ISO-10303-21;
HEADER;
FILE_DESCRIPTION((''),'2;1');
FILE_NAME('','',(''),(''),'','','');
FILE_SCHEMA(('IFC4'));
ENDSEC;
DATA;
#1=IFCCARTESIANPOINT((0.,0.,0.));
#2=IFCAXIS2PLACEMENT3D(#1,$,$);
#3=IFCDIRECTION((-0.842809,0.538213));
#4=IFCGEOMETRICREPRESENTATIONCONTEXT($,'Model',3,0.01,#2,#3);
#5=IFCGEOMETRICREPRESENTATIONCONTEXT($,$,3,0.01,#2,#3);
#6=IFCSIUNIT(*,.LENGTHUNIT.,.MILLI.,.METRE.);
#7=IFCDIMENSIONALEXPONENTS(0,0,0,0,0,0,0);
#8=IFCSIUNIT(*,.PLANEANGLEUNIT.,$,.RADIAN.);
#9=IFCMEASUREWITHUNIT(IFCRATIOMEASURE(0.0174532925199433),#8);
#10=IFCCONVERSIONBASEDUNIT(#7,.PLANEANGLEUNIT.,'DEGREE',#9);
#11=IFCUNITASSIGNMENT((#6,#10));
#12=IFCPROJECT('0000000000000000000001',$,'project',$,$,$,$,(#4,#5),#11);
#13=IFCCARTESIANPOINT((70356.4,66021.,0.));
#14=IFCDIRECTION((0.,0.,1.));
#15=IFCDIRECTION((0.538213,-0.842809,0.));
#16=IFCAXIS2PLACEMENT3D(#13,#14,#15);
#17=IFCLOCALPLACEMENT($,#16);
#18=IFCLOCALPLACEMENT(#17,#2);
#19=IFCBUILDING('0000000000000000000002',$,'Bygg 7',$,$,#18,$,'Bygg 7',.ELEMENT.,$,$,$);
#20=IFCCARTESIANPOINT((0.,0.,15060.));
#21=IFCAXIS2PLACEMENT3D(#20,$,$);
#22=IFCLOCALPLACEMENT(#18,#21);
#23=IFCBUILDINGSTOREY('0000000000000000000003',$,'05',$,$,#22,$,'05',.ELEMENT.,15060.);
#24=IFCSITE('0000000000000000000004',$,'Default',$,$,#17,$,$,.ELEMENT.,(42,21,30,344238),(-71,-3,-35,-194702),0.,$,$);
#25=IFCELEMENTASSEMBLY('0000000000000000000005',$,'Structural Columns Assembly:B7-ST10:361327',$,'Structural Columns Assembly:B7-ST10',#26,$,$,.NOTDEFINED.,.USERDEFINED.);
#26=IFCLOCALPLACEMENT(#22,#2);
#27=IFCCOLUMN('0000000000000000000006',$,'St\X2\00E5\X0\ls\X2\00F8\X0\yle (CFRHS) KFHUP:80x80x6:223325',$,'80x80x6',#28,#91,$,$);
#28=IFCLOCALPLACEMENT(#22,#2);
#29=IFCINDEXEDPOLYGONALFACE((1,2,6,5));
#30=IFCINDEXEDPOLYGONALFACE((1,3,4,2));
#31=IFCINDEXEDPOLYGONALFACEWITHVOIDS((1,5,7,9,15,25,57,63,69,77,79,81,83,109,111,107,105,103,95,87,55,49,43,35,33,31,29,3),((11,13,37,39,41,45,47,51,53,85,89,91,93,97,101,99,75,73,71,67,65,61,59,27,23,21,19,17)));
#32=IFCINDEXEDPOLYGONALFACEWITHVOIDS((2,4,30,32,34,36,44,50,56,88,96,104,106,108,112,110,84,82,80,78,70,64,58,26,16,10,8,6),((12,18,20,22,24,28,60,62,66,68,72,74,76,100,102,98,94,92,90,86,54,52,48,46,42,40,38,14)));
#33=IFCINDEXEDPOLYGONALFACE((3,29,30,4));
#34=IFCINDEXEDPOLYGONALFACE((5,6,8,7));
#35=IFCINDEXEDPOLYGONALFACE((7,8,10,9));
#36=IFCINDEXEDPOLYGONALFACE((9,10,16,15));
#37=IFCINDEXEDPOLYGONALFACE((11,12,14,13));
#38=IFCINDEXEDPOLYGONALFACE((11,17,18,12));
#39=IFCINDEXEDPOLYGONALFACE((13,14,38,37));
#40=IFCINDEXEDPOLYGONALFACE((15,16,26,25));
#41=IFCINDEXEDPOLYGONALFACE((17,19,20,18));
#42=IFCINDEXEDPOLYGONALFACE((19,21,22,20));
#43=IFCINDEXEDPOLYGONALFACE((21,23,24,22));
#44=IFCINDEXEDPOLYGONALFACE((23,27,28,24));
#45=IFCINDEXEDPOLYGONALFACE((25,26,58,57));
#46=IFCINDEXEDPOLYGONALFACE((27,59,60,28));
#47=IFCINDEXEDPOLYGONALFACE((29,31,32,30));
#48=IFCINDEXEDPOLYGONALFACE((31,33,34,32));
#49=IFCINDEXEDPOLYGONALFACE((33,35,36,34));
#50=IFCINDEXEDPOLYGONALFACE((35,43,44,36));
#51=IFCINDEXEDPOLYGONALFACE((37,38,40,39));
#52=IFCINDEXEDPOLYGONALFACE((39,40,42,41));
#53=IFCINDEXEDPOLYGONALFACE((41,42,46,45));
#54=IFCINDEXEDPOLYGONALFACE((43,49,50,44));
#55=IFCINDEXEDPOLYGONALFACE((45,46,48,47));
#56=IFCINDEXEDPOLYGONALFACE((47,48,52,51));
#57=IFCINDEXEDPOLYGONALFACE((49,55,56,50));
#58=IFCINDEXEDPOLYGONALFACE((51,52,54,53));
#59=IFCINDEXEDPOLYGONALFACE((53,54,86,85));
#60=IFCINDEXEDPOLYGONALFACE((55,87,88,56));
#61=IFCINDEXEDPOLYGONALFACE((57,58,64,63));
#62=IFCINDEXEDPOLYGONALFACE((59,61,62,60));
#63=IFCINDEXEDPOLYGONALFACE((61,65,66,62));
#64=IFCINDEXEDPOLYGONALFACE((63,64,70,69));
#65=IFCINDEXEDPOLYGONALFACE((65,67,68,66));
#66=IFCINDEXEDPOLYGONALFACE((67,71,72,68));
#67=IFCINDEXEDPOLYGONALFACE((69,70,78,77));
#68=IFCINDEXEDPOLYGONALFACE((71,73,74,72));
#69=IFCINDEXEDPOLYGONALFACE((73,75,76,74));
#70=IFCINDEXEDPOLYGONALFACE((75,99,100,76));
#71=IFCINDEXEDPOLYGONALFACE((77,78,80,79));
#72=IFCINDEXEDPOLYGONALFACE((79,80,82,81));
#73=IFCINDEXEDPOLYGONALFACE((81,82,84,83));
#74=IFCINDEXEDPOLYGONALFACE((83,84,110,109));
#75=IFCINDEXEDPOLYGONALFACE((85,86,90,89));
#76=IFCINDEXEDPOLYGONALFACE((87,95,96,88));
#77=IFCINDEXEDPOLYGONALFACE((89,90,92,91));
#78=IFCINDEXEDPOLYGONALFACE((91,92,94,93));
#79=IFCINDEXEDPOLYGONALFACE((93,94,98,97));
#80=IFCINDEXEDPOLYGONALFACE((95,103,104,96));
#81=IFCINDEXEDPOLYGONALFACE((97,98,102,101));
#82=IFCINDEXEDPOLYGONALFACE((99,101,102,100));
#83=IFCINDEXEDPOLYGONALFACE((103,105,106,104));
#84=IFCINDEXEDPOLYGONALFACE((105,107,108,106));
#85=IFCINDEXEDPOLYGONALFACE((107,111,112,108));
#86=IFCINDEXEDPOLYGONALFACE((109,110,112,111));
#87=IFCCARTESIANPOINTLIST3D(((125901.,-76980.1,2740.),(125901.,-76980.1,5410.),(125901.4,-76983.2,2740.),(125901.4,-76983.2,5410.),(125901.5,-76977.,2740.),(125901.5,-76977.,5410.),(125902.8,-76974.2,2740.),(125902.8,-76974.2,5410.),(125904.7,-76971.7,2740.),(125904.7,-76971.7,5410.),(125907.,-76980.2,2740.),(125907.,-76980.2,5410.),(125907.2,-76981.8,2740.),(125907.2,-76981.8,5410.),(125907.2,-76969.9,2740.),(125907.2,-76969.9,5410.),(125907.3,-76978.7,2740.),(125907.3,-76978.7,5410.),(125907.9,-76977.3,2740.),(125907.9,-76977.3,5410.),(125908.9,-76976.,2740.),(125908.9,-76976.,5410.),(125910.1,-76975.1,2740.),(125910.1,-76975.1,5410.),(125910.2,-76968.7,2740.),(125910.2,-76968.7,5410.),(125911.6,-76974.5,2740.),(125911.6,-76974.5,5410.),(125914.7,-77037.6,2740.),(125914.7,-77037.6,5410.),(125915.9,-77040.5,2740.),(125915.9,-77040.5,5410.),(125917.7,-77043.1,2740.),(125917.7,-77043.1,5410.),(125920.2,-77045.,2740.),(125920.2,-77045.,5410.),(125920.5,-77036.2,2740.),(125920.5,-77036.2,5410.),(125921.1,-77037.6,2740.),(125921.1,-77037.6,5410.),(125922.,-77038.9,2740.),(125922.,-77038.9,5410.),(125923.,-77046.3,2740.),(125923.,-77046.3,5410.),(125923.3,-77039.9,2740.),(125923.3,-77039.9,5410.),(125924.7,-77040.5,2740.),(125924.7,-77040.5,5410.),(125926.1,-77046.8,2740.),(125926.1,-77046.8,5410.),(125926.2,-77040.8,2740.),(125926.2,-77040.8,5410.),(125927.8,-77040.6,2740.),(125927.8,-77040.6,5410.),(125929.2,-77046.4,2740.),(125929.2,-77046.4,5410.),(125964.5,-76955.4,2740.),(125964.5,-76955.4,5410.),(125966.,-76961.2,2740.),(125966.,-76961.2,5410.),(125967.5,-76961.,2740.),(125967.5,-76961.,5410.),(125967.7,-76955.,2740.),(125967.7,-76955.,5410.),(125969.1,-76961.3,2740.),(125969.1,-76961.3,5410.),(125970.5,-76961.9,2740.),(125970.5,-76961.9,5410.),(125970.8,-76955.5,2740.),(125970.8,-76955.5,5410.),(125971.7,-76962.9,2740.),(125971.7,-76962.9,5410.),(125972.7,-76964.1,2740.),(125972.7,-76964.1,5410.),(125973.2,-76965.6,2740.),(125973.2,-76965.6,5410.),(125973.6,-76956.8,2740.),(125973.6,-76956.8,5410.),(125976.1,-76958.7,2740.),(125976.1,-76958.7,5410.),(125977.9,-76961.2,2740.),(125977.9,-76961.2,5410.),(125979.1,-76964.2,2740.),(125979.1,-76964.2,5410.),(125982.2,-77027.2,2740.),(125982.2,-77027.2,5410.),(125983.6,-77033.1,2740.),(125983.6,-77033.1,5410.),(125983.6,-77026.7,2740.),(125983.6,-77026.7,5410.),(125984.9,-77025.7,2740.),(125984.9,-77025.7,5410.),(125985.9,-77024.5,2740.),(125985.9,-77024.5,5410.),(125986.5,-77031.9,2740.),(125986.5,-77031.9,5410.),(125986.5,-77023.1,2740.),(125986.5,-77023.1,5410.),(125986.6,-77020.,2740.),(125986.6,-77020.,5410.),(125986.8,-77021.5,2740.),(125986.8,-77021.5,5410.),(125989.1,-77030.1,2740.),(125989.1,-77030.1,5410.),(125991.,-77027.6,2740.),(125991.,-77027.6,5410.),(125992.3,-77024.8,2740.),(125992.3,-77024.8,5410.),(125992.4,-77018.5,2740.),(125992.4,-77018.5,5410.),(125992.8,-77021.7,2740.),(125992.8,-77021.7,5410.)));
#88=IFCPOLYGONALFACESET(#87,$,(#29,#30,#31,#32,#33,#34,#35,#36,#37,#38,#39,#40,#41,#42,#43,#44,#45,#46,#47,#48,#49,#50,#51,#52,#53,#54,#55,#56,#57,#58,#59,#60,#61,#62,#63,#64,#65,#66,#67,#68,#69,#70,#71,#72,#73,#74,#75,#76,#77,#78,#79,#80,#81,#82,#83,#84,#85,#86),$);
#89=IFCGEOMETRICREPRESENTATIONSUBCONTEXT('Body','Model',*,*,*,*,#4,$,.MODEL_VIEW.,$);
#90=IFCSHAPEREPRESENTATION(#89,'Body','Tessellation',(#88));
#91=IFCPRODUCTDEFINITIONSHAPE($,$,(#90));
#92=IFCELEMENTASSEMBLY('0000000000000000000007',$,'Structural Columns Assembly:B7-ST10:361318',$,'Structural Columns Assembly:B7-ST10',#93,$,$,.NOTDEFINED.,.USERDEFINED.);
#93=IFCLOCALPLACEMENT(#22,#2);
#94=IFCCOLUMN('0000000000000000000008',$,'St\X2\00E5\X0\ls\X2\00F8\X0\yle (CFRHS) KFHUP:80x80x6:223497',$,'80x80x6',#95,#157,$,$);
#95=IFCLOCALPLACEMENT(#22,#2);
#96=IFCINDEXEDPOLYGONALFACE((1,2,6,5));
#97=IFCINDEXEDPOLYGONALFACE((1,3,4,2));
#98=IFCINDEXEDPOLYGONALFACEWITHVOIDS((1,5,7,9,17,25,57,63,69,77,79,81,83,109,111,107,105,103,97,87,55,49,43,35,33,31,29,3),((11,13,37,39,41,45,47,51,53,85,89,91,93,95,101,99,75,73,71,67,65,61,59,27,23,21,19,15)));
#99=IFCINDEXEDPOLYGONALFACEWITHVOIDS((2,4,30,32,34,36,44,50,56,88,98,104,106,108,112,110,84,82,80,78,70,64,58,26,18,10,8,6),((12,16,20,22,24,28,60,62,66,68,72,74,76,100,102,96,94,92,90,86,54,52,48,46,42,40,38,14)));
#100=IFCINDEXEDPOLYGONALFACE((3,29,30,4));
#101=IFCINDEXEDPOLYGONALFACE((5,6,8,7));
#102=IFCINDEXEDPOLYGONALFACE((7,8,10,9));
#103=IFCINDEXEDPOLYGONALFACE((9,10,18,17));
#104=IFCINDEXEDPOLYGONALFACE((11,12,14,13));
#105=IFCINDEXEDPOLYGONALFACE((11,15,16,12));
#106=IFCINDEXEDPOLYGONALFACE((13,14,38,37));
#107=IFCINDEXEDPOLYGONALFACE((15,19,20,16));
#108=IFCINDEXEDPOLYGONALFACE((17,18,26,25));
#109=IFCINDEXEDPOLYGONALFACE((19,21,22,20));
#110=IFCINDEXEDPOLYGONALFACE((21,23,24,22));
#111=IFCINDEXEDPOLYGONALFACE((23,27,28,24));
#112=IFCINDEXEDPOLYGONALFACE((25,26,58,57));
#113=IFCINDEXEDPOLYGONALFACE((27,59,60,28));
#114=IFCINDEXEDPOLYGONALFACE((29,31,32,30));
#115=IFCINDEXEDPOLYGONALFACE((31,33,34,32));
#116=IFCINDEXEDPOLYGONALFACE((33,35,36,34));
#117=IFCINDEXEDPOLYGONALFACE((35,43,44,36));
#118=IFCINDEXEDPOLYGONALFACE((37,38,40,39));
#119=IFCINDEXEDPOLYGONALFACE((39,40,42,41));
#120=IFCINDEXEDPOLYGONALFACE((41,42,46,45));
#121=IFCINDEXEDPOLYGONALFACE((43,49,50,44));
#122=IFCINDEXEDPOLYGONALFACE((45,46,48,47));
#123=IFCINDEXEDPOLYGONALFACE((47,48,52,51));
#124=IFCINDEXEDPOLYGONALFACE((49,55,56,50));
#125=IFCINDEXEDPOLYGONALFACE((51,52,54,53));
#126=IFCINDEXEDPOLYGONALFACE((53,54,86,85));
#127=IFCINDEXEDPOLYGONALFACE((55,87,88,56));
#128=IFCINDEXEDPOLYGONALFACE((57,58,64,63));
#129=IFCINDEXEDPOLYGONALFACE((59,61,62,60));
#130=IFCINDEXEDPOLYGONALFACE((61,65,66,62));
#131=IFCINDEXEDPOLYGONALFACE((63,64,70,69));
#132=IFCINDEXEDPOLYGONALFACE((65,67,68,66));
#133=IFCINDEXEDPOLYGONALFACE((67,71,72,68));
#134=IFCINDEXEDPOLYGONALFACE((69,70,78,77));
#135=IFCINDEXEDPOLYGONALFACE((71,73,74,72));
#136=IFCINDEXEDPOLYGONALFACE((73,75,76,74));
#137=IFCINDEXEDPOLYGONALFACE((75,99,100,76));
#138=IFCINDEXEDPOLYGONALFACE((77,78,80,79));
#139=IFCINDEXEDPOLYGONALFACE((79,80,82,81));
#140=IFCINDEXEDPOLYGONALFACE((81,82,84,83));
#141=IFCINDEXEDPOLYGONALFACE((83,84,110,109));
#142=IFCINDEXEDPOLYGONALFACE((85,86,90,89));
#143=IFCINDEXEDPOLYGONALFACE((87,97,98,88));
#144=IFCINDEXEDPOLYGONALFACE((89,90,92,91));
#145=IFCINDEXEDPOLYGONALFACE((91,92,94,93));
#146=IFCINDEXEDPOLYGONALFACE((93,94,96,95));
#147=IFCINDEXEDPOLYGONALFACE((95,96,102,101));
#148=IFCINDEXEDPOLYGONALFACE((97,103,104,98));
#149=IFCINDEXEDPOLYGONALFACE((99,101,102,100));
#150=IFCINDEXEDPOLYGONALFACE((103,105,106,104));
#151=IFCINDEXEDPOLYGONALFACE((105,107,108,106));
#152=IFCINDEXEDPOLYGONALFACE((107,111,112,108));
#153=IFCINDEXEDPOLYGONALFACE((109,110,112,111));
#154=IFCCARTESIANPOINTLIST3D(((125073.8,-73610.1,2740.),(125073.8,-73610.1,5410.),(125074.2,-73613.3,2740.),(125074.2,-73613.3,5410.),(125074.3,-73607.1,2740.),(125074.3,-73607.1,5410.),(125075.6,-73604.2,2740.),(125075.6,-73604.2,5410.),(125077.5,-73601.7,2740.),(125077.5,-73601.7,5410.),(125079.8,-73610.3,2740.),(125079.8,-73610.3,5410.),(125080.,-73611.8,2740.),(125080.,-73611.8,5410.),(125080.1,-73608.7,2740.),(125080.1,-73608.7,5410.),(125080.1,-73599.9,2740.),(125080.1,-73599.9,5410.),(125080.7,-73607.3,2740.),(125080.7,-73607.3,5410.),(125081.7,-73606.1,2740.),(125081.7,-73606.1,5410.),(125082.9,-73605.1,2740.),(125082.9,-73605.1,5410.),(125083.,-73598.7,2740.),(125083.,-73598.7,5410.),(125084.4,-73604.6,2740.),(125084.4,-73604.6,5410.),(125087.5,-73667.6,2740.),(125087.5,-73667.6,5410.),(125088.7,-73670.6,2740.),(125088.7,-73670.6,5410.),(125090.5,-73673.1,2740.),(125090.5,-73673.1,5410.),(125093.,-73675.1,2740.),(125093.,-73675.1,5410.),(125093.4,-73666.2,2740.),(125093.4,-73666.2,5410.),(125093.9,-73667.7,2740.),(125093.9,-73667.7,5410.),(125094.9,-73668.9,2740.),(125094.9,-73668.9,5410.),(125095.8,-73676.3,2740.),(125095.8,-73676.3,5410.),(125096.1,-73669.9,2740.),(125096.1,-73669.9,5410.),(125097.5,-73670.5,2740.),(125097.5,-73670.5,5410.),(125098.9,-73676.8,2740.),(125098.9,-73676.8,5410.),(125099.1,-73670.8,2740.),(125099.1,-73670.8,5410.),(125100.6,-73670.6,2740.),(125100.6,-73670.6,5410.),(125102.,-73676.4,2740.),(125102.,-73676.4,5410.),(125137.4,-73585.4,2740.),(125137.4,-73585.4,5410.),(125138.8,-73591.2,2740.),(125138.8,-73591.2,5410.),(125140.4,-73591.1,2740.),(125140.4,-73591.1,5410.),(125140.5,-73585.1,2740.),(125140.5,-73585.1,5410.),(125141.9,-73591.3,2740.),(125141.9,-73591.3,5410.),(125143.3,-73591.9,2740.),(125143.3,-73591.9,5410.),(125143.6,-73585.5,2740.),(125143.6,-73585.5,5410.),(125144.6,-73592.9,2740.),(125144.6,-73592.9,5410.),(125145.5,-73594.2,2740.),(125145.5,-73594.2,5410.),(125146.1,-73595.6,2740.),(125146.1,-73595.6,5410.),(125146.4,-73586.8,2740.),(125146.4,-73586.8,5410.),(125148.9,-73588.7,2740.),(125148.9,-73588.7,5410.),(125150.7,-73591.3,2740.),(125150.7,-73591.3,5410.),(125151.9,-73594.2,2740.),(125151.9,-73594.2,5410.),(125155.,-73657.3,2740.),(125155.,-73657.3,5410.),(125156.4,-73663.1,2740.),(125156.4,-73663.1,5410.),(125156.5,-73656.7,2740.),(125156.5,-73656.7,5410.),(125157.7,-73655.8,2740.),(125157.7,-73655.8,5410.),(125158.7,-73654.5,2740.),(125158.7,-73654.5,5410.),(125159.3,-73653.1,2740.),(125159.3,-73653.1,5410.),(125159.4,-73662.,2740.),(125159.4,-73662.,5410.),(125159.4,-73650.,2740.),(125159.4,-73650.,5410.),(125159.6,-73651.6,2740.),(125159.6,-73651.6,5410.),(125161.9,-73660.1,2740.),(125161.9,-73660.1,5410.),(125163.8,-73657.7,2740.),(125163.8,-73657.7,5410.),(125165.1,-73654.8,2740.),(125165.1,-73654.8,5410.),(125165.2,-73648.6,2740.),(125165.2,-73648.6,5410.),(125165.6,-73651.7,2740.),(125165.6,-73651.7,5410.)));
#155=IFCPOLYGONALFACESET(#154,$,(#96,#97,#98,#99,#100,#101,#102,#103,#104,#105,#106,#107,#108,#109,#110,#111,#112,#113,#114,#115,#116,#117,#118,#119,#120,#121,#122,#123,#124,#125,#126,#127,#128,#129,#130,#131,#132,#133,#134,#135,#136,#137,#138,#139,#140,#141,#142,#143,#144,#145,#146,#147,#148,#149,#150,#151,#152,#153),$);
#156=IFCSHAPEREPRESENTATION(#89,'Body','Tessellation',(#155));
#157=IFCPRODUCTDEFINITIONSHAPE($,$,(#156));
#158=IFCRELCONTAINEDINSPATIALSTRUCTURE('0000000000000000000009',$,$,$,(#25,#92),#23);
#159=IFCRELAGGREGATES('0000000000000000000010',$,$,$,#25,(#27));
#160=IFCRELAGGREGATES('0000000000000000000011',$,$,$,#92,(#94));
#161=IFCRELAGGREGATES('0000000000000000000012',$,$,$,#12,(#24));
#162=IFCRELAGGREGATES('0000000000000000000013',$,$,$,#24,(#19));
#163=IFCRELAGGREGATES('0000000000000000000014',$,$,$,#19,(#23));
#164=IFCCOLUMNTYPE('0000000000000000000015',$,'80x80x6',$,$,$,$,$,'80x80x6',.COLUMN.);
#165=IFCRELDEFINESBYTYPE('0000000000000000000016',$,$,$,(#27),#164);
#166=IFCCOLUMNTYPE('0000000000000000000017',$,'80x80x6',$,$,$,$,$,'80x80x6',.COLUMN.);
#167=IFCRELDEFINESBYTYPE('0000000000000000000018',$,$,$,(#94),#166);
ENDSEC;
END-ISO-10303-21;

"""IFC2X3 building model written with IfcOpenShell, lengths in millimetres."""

from ifc_helpers import new_model, entity, si_unit, converted_unit, direction, frame, frame_2d, origin, place, context, subcontext, project, spatial, polyline, circle_curve, parameter, trimmed, segment, composite_curve, outline, extrude, source, transform, mapped, type_object, type_shapes, element, aggregate, save


model = new_model("IFC2X3")

# Units and contexts
model_context = context("Model", 3, precision=0.01, world=origin(), true_north=direction((-0.842809, 0.538213)))
context_of_model = context(None, 3, precision=0.01, world=origin(), true_north=direction((-0.842809, 0.538213)))
body_context = subcontext(model_context, "Body", "Model", "MODEL_VIEW")
ifc_project = project(units=[si_unit("LENGTHUNIT", "METRE", prefix="MILLI"), converted_unit("PLANEANGLEUNIT", "DEGREE", entity("IfcRatioMeasure", 0.0174532925199433), si_unit("PLANEANGLEUNIT", "RADIAN"), dimensions=[0, 0, 0, 0, 0, 0, 0])], contexts=[model_context, context_of_model])

# Site, building, storey
site_placement = place(None, frame((70356.4, 66021.0, 0.0), z_axis=(0.0, 0.0, 1.0), x_axis=(0.538213, -0.842809, 0.0)))
site = spatial("IfcSite", under=ifc_project, at=site_placement, Name="Default", CompositionType="ELEMENT", RefLatitude=(42, 21, 30, 344238), RefLongitude=(-71, -3, -35, -194702), RefElevation=0.0)
building_placement = place(site_placement, origin())
building = spatial("IfcBuilding", under=site, at=building_placement, Name="Bygg 7", LongName="Bygg 7", CompositionType="ELEMENT")
storey_placement = place(building_placement, frame((0.0, 0.0, 15060.0)))
storey = spatial("IfcBuildingStorey", under=building, at=storey_placement, Name="05", LongName="05", CompositionType="ELEMENT", Elevation=15060.0)

# Element assemblies, columns
assembly_1_placement = place(storey_placement, origin())
assembly_1 = element("IfcElementAssembly", 1, at=assembly_1_placement, inside=storey, Name="Structural Columns Assembly:B7-ST10:361327", ObjectType="Structural Columns Assembly:B7-ST10", AssemblyPlace="NOTDEFINED", PredefinedType="USERDEFINED")
column_type_1 = type_object("IfcColumnType", Name="80x80x6", ElementType="80x80x6", PredefinedType="COLUMN")
shared_shape_1 = source(origin(), body_context, "Body", "SweptSolid", [
    extrude(outline(composite_curve([segment(trimmed(circle_curve(frame_2d((-28.0, 28.0), x_axis=(1.0, 0.0)), 12.0), [parameter(90.0)], [parameter(180.0)], True, "PARAMETER"), True, "CONTINUOUS"), segment(polyline([(-40.0, 28.0), (-40.0, -28.0)]), True, "CONTINUOUS"), segment(trimmed(circle_curve(frame_2d((-28.0, -28.0), x_axis=(1.0, 0.0)), 12.0), [parameter(180.0)], [parameter(270.0)], True, "PARAMETER"), True, "CONTINUOUS"), segment(polyline([(-28.0, -40.0), (28.0, -40.0)]), True, "CONTINUOUS"), segment(trimmed(circle_curve(frame_2d((28.0, -28.0), x_axis=(1.0, 0.0)), 12.0), [parameter(270.0)], [parameter(0.0)], True, "PARAMETER"), True, "CONTINUOUS"), segment(polyline([(40.0, -28.0), (40.0, 28.0)]), True, "CONTINUOUS"), segment(trimmed(circle_curve(frame_2d((28.0, 28.0), x_axis=(1.0, 0.0)), 12.0), [parameter(0.0)], [parameter(90.0)], True, "PARAMETER"), True, "CONTINUOUS"), segment(polyline([(28.0, 40.0), (-28.0, 40.0)]), True, "CONTINUOUS")], self_intersect=False), holes=[composite_curve([segment(polyline([(-28.0, 34.0), (28.0, 34.0)]), True, "CONTINUOUS"), segment(trimmed(circle_curve(frame_2d((28.0, 28.0), x_axis=(1.0, 0.0)), 6.0), [parameter(360.0)], [parameter(90.0)], True, "PARAMETER"), False, "CONTINUOUS"), segment(polyline([(34.0, 28.0), (34.0, -28.0)]), True, "CONTINUOUS"), segment(trimmed(circle_curve(frame_2d((28.0, -28.0), x_axis=(1.0, 0.0)), 6.0), [parameter(270.0)], [parameter(360.0)], True, "PARAMETER"), False, "CONTINUOUS"), segment(polyline([(28.0, -34.0), (-28.0, -34.0)]), True, "CONTINUOUS"), segment(trimmed(circle_curve(frame_2d((-28.0, -28.0), x_axis=(1.0, 0.0)), 6.0), [parameter(180.0)], [parameter(270.0)], True, "PARAMETER"), False, "CONTINUOUS"), segment(polyline([(-34.0, -28.0), (-34.0, 28.0)]), True, "CONTINUOUS"), segment(trimmed(circle_curve(frame_2d((-28.0, 28.0), x_axis=(1.0, 0.0)), 6.0), [parameter(90.0)], [parameter(180.0)], True, "PARAMETER"), False, "CONTINUOUS")], self_intersect=False)]), frame((47.5, 47.5, 0.0), z_axis=(0.0, 0.0, 1.0), x_axis=(-0.971172, -0.238381, 0.0)), (0.0, 0.0, 1.0), 2670.0),
])
type_shapes(column_type_1, [shared_shape_1])
column_1_placement = place(assembly_1_placement, frame((125899.4, -77048.3, 2740.0)))
column_1 = element("IfcColumn", 2, at=column_1_placement, type_object=column_type_1, Name="Stålsøyle (CFRHS) KFHUP:80x80x6:223325", ObjectType="80x80x6", context=body_context, shape_type="MappedRepresentation", body=[
    mapped(shared_shape_1, transform((0.0, 0.0, 0.0), scale=1.0)),
])
aggregate(assembly_1, [column_1])
assembly_2_placement = place(storey_placement, origin())
assembly_2 = element("IfcElementAssembly", 3, at=assembly_2_placement, inside=storey, Name="Structural Columns Assembly:B7-ST10:361318", ObjectType="Structural Columns Assembly:B7-ST10", AssemblyPlace="NOTDEFINED", PredefinedType="USERDEFINED")
column_type_2 = type_object("IfcColumnType", Name="80x80x6", ElementType="80x80x6", PredefinedType="COLUMN")
shared_shape_2 = source(origin(), body_context, "Body", "SweptSolid", [
    extrude(outline(composite_curve([segment(trimmed(circle_curve(frame_2d((-28.0, 28.0), x_axis=(1.0, 0.0)), 12.0), [parameter(90.0)], [parameter(180.0)], True, "PARAMETER"), True, "CONTINUOUS"), segment(polyline([(-40.0, 28.0), (-40.0, -28.0)]), True, "CONTINUOUS"), segment(trimmed(circle_curve(frame_2d((-28.0, -28.0), x_axis=(1.0, 0.0)), 12.0), [parameter(180.0)], [parameter(270.0)], True, "PARAMETER"), True, "CONTINUOUS"), segment(polyline([(-28.0, -40.0), (28.0, -40.0)]), True, "CONTINUOUS"), segment(trimmed(circle_curve(frame_2d((28.0, -28.0), x_axis=(1.0, 0.0)), 12.0), [parameter(270.0)], [parameter(0.0)], True, "PARAMETER"), True, "CONTINUOUS"), segment(polyline([(40.0, -28.0), (40.0, 28.0)]), True, "CONTINUOUS"), segment(trimmed(circle_curve(frame_2d((28.0, 28.0), x_axis=(1.0, 0.0)), 12.0), [parameter(0.0)], [parameter(90.0)], True, "PARAMETER"), True, "CONTINUOUS"), segment(polyline([(28.0, 40.0), (-28.0, 40.0)]), True, "CONTINUOUS")], self_intersect=False), holes=[composite_curve([segment(polyline([(-28.0, 34.0), (28.0, 34.0)]), True, "CONTINUOUS"), segment(trimmed(circle_curve(frame_2d((28.0, 28.0), x_axis=(1.0, 0.0)), 6.0), [parameter(360.0)], [parameter(90.0)], True, "PARAMETER"), False, "CONTINUOUS"), segment(polyline([(34.0, 28.0), (34.0, -28.0)]), True, "CONTINUOUS"), segment(trimmed(circle_curve(frame_2d((28.0, -28.0), x_axis=(1.0, 0.0)), 6.0), [parameter(270.0)], [parameter(360.0)], True, "PARAMETER"), False, "CONTINUOUS"), segment(polyline([(28.0, -34.0), (-28.0, -34.0)]), True, "CONTINUOUS"), segment(trimmed(circle_curve(frame_2d((-28.0, -28.0), x_axis=(1.0, 0.0)), 6.0), [parameter(180.0)], [parameter(270.0)], True, "PARAMETER"), False, "CONTINUOUS"), segment(polyline([(-34.0, -28.0), (-34.0, 28.0)]), True, "CONTINUOUS"), segment(trimmed(circle_curve(frame_2d((-28.0, 28.0), x_axis=(1.0, 0.0)), 6.0), [parameter(90.0)], [parameter(180.0)], True, "PARAMETER"), False, "CONTINUOUS")], self_intersect=False)]), frame((47.5, 47.5, 0.0), z_axis=(0.0, 0.0, 1.0), x_axis=(-0.971172, -0.238381, 0.0)), (0.0, 0.0, 1.0), 2670.0),
])
type_shapes(column_type_2, [shared_shape_2])
column_2_placement = place(assembly_2_placement, frame((125072.2, -73678.4, 2740.0)))
column_2 = element("IfcColumn", 4, at=column_2_placement, type_object=column_type_2, Name="Stålsøyle (CFRHS) KFHUP:80x80x6:223497", ObjectType="80x80x6", context=body_context, shape_type="MappedRepresentation", body=[
    mapped(shared_shape_2, transform((0.0, 0.0, 0.0), scale=1.0)),
])
aggregate(assembly_2, [column_2])

save(model, "model.ifc")
